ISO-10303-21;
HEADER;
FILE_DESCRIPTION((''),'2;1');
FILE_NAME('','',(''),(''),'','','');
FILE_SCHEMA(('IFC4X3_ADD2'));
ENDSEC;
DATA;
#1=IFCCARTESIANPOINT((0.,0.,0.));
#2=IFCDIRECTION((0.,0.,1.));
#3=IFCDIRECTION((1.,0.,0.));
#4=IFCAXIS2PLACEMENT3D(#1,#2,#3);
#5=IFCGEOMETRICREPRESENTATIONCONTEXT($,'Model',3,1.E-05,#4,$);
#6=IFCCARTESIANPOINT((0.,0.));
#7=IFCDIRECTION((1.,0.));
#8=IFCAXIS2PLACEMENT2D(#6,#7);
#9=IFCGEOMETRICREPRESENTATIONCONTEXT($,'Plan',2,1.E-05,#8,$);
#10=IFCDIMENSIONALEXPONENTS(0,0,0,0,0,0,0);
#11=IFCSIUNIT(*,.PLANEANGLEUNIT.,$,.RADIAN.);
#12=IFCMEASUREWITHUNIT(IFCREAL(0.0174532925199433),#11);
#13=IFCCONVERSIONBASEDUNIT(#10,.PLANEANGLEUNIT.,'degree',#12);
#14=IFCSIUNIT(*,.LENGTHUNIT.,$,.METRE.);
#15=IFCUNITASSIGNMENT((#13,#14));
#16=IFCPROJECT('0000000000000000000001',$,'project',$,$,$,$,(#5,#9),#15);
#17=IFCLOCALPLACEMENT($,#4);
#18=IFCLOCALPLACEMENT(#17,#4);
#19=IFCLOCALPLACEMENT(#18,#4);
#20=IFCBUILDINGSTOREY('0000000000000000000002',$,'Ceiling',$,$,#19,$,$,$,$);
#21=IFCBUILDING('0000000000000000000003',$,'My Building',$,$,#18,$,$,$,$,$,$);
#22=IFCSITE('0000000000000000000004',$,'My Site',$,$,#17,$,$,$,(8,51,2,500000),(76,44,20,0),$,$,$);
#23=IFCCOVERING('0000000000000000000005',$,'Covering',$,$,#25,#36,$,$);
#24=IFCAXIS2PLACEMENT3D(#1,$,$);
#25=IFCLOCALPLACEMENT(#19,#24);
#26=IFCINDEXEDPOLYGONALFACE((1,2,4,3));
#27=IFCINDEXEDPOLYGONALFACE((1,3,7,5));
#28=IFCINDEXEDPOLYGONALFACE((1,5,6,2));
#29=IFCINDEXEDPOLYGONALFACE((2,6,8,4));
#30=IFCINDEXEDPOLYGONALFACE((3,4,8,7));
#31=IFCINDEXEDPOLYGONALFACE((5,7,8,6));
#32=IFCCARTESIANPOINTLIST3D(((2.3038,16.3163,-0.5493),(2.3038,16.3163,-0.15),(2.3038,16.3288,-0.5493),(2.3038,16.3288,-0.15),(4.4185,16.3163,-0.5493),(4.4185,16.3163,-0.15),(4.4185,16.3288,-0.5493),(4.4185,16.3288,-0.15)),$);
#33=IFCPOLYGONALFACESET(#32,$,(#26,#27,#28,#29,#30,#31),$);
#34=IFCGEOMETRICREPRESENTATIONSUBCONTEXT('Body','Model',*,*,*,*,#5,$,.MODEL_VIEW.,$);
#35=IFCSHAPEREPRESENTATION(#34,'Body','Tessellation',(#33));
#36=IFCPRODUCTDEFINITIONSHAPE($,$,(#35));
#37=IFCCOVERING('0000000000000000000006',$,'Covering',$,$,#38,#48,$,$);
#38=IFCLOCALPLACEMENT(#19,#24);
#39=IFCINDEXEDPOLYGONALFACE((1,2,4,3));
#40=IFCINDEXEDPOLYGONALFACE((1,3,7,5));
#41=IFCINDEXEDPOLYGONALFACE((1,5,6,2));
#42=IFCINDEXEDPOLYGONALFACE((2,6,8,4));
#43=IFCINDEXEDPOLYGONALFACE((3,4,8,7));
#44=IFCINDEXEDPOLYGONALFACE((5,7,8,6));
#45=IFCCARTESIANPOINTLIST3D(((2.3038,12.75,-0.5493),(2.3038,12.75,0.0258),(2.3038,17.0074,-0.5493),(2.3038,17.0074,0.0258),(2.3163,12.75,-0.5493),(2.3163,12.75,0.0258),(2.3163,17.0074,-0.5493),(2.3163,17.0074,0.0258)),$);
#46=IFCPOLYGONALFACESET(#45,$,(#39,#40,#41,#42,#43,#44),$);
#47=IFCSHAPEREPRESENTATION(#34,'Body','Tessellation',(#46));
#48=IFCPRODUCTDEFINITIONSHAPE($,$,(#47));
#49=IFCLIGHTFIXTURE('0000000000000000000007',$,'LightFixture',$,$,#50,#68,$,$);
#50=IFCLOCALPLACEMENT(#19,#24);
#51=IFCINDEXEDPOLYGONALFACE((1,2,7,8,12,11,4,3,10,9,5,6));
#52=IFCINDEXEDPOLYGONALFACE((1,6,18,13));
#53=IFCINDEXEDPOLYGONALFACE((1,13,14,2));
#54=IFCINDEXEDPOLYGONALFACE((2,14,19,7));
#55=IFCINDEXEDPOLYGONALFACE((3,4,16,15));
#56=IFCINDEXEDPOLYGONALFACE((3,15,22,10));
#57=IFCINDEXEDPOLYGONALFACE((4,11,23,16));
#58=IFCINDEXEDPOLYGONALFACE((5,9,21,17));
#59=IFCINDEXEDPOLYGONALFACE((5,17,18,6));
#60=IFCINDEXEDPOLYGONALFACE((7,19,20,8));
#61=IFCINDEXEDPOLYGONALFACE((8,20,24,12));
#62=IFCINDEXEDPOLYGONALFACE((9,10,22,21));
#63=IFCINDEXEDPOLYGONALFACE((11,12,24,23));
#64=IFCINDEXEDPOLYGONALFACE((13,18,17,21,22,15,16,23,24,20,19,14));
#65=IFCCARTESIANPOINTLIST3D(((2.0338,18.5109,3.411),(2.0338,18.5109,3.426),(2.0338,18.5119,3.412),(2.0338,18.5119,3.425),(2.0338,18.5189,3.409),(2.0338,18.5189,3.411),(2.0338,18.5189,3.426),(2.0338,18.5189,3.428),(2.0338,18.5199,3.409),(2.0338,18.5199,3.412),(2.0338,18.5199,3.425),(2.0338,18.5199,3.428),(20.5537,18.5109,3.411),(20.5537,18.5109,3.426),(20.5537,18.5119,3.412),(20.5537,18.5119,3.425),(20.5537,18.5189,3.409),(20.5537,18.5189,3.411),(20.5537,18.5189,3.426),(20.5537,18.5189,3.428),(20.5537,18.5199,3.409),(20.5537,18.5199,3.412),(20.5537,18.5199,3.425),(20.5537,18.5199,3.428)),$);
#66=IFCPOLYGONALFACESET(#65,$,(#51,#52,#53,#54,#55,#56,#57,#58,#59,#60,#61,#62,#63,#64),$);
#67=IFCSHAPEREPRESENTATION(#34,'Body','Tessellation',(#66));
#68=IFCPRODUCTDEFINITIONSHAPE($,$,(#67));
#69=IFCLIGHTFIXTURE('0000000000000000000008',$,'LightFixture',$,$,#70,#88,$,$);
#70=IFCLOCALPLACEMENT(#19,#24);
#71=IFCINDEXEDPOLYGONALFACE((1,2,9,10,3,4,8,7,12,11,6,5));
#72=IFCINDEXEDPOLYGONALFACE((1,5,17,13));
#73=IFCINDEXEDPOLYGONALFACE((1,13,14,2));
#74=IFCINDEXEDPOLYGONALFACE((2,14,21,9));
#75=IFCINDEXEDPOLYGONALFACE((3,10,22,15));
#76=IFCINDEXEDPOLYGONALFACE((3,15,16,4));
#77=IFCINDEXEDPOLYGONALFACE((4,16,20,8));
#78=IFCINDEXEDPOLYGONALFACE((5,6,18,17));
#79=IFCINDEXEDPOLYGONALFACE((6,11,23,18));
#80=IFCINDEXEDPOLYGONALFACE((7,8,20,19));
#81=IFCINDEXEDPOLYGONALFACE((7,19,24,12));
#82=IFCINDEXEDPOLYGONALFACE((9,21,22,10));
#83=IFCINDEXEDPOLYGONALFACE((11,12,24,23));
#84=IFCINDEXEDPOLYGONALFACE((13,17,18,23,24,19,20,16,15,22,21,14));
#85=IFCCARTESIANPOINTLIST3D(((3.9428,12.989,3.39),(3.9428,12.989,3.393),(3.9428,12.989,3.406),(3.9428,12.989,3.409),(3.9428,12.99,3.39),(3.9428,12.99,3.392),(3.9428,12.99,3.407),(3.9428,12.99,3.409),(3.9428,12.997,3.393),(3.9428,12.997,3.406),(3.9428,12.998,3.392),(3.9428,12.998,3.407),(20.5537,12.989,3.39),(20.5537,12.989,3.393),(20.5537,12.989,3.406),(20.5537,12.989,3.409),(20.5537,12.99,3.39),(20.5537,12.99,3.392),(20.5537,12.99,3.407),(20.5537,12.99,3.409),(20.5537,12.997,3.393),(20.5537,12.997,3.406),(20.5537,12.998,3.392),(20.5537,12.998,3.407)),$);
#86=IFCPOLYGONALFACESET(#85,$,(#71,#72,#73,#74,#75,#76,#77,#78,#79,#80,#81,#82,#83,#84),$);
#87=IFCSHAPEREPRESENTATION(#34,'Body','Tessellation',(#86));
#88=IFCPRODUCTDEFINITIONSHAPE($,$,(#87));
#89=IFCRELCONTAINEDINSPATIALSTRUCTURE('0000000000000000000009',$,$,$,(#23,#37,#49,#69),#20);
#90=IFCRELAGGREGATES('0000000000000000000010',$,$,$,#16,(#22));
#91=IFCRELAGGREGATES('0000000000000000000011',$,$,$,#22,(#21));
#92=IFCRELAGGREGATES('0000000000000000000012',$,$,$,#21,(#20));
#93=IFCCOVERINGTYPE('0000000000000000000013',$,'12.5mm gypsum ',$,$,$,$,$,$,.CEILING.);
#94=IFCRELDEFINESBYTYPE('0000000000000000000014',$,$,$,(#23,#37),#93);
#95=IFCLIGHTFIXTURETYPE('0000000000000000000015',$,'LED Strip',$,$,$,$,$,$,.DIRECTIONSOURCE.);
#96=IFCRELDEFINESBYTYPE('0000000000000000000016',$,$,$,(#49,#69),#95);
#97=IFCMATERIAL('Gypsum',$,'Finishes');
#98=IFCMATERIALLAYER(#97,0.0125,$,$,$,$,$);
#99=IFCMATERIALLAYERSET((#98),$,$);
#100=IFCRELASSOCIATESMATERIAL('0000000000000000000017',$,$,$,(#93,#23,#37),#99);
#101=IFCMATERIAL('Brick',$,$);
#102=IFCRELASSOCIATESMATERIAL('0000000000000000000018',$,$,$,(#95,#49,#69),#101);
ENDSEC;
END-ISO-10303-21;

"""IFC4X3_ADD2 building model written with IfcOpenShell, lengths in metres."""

from ifc_helpers import new_model, entity, si_unit, converted_unit, frame, origin_with_axes, origin_2d_with_axis, place, context, subcontext, project, spatial, line, indexed_curve, outline, extrude, material, layer, layer_set, layer_usage, material_profile, profile_set, profile_usage, type_object, element, save


model = new_model("IFC4X3_ADD2")

# Units and contexts
model_context = context("Model", 3, precision=1e-05, world=origin_with_axes())
plan_context = context("Plan", 2, precision=1e-05, world=origin_2d_with_axis())
body_context = subcontext(model_context, "Body", "Model", "MODEL_VIEW")
ifc_project = project(units=[converted_unit("PLANEANGLEUNIT", "degree", entity("IfcReal", 0.0174532925199433), si_unit("PLANEANGLEUNIT", "RADIAN"), dimensions=[0, 0, 0, 0, 0, 0, 0]), si_unit("LENGTHUNIT", "METRE")], contexts=[model_context, plan_context])

# Site, building, storey
site_placement = place(None, origin_with_axes())
site = spatial("IfcSite", under=ifc_project, at=site_placement, Name="My Site", RefLatitude=(8, 51, 2, 500000), RefLongitude=(76, 44, 20, 0))
building_placement = place(site_placement, origin_with_axes())
building = spatial("IfcBuilding", under=site, at=building_placement, Name="My Building")
storey_placement = place(building_placement, origin_with_axes())
storey = spatial("IfcBuildingStorey", under=building, at=storey_placement, Name="Ceiling")

# Coverings
ifc_material_1 = material(Name="Gypsum", Category="Finishes")
ifc_layer_1 = layer(ifc_material_1, 0.0125)
ifc_layer_set_1 = layer_set([ifc_layer_1])
covering_type_1 = type_object("IfcCoveringType", Name="12.5mm gypsum ", PredefinedType="CEILING", material=ifc_layer_set_1)
ifc_layer_usage_1 = layer_usage(ifc_layer_set_1, "AXIS2", "POSITIVE", 0.0)
covering_1_placement = place(storey_placement, frame((4.4185, 16.3288, -0.5493), z_axis=(0.0, 0.0, 1.0), x_axis=(-1.0, 0.0, 0.0)))
element("IfcCovering", 1, at=covering_1_placement, inside=storey, type_object=covering_type_1, material=ifc_layer_usage_1, Name="Covering", context=body_context, shape_type="SweptSolid", body=[
    extrude(outline(indexed_curve([(0.0, 0.0), (0.0, 0.0125), (2.1147, 0.0125), (2.1147, 0.0)], segments=[line(1, 2, 3, 4, 1)])), origin_with_axes(), (0.0, 0.0, 1.0), 0.3993),
])
ifc_layer_usage_2 = layer_usage(ifc_layer_set_1, "AXIS2", "POSITIVE", 0.0)
covering_2_placement = place(storey_placement, frame((2.3038, 17.0074, -0.5493), z_axis=(0.0, 0.0, 1.0), x_axis=(-0.000001, -1.0, 0.0)))
element("IfcCovering", 2, at=covering_2_placement, inside=storey, type_object=covering_type_1, material=ifc_layer_usage_2, Name="Covering", context=body_context, shape_type="SweptSolid", body=[
    extrude(outline(indexed_curve([(0.0, 0.0), (0.0, 0.0125), (4.2574, 0.0125), (4.2574, 0.0)], segments=[line(1, 2, 3, 4, 1)])), origin_with_axes(), (0.0, 0.0, 1.0), 0.575),
])

# Light fixtures
ifc_material_2 = material(Name="Brick")
ifc_material_profile = material_profile(ifc_material_2, outline(indexed_curve([(0.003, 0.0), (0.003, 0.008), (0.016, 0.008), (0.016, 0.0), (0.019, 0.0), (0.019, 0.001), (0.017, 0.001), (0.017, 0.009), (0.002, 0.009), (0.002, 0.001), (0.0, 0.001), (0.0, 0.0), (0.003, 0.0)])))
ifc_profile_set = profile_set([ifc_material_profile])
ifc_profile_usage_1 = profile_usage(ifc_profile_set, cardinal=5)
light_fixture_type = type_object("IfcLightFixtureType", Name="LED Strip", PredefinedType="DIRECTIONSOURCE", material=ifc_profile_set)
light_fixture_1_placement = place(storey_placement, frame((2.0338, 18.5199, 3.409), z_axis=(1.0, 0.0, 0.0), x_axis=(0.0, 0.0, 1.0)))
element("IfcLightFixture", 3, at=light_fixture_1_placement, inside=storey, type_object=light_fixture_type, material=ifc_profile_usage_1, Name="LightFixture", context=body_context, shape_type="SweptSolid", body=[
    extrude(outline(indexed_curve([(0.003, 0.0), (0.003, 0.008), (0.016, 0.008), (0.016, 0.0), (0.019, 0.0), (0.019, 0.001), (0.017, 0.001), (0.017, 0.009), (0.002, 0.009), (0.002, 0.001), (0.0, 0.001), (0.0, 0.0), (0.003, 0.0)])), origin_with_axes(), (0.0, 0.0, 1.0), 18.5199),
])
ifc_profile_usage_2 = profile_usage(ifc_profile_set, cardinal=5)
light_fixture_2_placement = place(storey_placement, frame((3.9428, 12.989, 3.409), z_axis=(1.0, 0.0, 0.0), x_axis=(0.0, 0.0, -1.0)))
element("IfcLightFixture", 4, at=light_fixture_2_placement, inside=storey, type_object=light_fixture_type, material=ifc_profile_usage_2, Name="LightFixture", context=body_context, shape_type="SweptSolid", body=[
    extrude(outline(indexed_curve([(0.003, 0.0), (0.003, 0.008), (0.016, 0.008), (0.016, 0.0), (0.019, 0.0), (0.019, 0.001), (0.017, 0.001), (0.017, 0.009), (0.002, 0.009), (0.002, 0.001), (0.0, 0.001), (0.0, 0.0), (0.003, 0.0)])), origin_with_axes(), (0.0, 0.0, 1.0), 16.6109),
])

save(model, "model.ifc")
